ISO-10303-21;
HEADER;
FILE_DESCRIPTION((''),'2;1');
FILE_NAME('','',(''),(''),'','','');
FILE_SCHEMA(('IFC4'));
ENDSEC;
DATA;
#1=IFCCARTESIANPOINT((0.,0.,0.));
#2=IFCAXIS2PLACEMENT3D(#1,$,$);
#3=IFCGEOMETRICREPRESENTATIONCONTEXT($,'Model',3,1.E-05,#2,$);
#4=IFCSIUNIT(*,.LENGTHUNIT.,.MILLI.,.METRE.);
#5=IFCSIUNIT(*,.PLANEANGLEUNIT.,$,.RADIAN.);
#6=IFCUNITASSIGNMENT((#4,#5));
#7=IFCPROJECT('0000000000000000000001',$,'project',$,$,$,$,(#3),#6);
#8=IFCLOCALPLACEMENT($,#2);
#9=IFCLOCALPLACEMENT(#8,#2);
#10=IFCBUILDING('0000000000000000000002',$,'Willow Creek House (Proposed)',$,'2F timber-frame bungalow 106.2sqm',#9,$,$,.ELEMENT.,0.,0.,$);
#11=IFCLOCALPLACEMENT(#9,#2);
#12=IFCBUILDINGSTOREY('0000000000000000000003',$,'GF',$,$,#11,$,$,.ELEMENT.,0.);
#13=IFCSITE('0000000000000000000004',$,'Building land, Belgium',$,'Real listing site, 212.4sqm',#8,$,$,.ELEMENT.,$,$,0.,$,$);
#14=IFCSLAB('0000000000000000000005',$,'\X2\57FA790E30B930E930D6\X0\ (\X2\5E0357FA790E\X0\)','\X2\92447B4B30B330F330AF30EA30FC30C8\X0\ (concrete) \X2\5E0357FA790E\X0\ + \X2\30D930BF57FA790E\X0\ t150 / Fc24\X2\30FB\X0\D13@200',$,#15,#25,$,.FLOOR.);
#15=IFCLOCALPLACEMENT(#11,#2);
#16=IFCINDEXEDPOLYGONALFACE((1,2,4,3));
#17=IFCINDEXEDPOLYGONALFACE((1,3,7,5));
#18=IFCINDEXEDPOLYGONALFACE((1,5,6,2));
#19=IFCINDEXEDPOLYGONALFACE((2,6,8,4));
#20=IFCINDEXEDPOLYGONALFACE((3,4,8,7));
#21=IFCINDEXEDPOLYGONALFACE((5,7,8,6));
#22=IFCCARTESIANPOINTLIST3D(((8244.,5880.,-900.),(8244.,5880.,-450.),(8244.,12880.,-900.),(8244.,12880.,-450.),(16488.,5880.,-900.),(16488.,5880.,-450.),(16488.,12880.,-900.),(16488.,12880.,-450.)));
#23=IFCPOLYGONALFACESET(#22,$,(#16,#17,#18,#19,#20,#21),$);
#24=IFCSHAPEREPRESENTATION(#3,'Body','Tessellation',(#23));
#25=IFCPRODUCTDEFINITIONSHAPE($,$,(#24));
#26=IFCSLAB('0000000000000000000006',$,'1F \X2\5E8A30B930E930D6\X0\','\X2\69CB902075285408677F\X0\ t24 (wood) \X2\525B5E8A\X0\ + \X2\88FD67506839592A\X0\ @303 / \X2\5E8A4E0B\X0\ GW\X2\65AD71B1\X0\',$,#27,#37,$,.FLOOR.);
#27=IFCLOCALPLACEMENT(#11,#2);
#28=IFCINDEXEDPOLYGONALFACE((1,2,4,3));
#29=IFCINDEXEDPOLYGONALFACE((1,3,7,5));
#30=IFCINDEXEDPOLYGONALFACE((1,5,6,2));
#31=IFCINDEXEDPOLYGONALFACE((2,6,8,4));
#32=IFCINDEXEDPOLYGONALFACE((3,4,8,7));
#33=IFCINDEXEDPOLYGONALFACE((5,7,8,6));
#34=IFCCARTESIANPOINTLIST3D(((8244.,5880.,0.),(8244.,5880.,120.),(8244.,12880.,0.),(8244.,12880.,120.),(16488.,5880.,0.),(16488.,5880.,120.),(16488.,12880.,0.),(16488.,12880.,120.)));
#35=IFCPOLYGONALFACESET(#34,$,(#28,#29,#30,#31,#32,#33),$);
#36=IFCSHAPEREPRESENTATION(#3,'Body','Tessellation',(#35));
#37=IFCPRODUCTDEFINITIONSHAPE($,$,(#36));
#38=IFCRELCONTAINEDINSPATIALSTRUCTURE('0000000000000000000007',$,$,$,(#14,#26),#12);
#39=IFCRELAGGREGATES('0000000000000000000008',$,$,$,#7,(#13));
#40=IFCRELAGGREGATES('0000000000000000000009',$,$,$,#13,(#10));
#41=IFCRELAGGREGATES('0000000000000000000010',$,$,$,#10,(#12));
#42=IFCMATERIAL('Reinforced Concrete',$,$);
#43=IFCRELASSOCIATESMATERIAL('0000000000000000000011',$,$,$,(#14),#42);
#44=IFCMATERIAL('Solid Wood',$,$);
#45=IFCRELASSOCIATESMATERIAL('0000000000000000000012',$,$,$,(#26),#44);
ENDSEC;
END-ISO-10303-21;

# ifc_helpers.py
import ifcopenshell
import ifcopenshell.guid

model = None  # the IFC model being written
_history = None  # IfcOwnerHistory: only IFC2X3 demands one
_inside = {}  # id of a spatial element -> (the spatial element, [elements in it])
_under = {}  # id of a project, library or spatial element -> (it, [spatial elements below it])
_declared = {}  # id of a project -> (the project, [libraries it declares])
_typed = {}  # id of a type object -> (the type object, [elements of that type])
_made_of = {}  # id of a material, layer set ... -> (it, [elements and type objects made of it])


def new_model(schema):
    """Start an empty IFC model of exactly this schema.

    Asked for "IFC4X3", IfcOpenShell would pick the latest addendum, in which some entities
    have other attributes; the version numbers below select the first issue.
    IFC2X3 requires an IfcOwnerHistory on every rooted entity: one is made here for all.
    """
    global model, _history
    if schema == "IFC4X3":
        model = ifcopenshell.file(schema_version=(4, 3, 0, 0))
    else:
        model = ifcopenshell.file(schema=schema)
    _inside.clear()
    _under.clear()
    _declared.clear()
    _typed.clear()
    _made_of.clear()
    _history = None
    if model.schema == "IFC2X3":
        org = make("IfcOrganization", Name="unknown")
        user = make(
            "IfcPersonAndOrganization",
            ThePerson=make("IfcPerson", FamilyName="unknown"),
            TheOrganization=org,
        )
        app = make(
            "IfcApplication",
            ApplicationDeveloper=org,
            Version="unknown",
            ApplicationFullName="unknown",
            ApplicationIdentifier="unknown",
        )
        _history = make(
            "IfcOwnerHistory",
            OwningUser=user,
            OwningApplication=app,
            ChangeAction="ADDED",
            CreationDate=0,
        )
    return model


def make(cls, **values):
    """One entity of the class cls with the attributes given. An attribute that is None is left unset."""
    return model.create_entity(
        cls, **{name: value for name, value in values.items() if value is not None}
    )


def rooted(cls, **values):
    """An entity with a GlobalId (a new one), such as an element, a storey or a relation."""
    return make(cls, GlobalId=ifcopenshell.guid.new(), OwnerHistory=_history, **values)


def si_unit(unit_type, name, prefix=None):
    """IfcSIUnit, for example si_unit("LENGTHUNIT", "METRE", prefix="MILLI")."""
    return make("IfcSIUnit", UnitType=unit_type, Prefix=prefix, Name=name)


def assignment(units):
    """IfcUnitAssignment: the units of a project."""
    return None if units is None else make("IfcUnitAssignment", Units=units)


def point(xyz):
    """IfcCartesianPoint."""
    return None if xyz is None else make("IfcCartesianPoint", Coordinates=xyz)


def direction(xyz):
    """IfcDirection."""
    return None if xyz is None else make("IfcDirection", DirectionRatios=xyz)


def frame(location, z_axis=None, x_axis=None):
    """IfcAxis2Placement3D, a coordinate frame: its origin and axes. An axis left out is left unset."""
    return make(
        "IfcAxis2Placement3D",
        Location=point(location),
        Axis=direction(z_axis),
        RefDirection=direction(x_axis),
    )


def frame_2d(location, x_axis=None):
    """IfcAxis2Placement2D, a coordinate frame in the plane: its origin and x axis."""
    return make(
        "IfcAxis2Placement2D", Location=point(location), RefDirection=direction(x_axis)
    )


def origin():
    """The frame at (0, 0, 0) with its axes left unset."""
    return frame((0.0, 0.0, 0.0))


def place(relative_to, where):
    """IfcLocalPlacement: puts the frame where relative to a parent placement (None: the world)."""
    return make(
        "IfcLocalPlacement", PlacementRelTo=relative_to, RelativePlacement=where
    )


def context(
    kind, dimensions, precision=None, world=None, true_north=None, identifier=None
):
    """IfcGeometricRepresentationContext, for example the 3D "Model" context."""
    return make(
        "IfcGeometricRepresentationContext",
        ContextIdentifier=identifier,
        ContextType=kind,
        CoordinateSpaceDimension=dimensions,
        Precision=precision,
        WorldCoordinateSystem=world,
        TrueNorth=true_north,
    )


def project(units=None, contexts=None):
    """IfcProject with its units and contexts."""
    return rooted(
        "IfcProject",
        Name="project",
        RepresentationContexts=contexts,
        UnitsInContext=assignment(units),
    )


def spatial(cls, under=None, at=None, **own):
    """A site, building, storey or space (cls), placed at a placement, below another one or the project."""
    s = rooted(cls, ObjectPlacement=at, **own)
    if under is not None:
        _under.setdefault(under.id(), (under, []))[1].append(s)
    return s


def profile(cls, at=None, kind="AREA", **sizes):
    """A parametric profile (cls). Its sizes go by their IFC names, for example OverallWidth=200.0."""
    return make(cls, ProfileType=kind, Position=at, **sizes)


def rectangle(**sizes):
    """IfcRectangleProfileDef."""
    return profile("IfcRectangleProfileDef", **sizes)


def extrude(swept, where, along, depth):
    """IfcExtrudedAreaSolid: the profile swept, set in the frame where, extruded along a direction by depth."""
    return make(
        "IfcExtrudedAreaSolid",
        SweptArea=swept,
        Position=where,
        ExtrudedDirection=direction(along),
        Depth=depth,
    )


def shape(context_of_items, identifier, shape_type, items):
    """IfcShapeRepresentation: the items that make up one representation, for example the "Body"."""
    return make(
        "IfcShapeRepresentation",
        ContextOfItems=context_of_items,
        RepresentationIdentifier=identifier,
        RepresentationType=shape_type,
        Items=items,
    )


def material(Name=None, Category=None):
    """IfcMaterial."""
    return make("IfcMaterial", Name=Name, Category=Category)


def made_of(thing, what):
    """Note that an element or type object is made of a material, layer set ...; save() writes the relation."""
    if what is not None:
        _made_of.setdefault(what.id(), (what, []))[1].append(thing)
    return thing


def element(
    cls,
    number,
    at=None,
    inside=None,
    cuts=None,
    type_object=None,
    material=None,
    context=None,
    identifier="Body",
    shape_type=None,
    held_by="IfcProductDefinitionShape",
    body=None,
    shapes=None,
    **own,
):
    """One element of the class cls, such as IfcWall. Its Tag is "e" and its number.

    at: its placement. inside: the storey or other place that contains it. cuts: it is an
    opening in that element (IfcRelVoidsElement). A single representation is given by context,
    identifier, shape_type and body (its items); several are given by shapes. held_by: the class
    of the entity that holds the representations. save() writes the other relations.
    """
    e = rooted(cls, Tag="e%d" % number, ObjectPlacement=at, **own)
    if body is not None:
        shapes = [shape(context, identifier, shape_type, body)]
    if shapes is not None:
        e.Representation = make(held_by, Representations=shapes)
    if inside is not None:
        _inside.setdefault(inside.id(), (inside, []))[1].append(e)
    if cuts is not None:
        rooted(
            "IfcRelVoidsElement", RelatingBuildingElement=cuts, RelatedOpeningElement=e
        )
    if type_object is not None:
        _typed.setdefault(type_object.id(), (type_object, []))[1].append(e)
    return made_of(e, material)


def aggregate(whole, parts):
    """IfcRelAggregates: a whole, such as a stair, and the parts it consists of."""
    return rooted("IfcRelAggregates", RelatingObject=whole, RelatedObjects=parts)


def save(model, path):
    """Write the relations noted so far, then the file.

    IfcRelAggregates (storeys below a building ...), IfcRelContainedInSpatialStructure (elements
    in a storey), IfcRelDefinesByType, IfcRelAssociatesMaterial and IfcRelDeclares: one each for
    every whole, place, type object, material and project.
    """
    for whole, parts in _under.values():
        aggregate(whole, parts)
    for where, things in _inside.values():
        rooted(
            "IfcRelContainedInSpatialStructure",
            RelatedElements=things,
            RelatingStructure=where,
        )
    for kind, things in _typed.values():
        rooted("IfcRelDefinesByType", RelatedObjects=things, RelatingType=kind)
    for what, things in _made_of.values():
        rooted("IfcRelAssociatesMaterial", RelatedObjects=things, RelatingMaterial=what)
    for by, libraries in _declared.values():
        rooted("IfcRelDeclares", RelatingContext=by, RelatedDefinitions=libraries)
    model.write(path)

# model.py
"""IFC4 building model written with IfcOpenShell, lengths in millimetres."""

from ifc_helpers import new_model, si_unit, frame, frame_2d, origin, place, context, project, spatial, rectangle, extrude, material, element, save


model = new_model("IFC4")

# Units and contexts
model_context = context("Model", 3, precision=1e-05, world=origin())
ifc_project = project(units=[si_unit("LENGTHUNIT", "METRE", prefix="MILLI"), si_unit("PLANEANGLEUNIT", "RADIAN")], contexts=[model_context])

# Site, building, storey
site_placement = place(None, origin())
site = spatial("IfcSite", under=ifc_project, at=site_placement, Name="Building land, Belgium", ObjectType="Real listing site, 212.4sqm", CompositionType="ELEMENT", RefElevation=0.0)
building_placement = place(site_placement, origin())
building = spatial("IfcBuilding", under=site, at=building_placement, Name="Willow Creek House (Proposed)", ObjectType="2F timber-frame bungalow 106.2sqm", CompositionType="ELEMENT", ElevationOfRefHeight=0.0, ElevationOfTerrain=0.0)
storey_placement = place(building_placement, origin())
storey = spatial("IfcBuildingStorey", under=building, at=storey_placement, Name="GF", CompositionType="ELEMENT", Elevation=0.0)

# Slabs
ifc_material_1 = material(Name="Reinforced Concrete")
slab_1_placement = place(storey_placement, frame((4122.0, 2940.0, -450.0)))
element("IfcSlab", 1, at=slab_1_placement, inside=storey, material=ifc_material_1, Name="基礎スラブ (布基礎)", Description="鉄筋コンクリート (concrete) 布基礎 + ベタ基礎 t150 / Fc24・D13@200", PredefinedType="FLOOR", context=model_context, shape_type="SweptSolid", body=[
    extrude(rectangle(XDim=8244.0, YDim=7000.0, at=frame_2d((4122.0, 3500.0))), frame((4122.0, 2940.0, -450.0)), (0.0, 0.0, 1.0), 450.0),
])
ifc_material_2 = material(Name="Solid Wood")
slab_2_placement = place(storey_placement, frame((4122.0, 2940.0, 0.0)))
element("IfcSlab", 2, at=slab_2_placement, inside=storey, material=ifc_material_2, Name="1F 床スラブ", Description="構造用合板 t24 (wood) 剛床 + 製材根太 @303 / 床下 GW断熱", PredefinedType="FLOOR", context=model_context, shape_type="SweptSolid", body=[
    extrude(rectangle(XDim=8244.0, YDim=7000.0, at=frame_2d((4122.0, 3500.0))), frame((4122.0, 2940.0, 0.0)), (0.0, 0.0, 1.0), 120.0),
])

save(model, "model.ifc")
